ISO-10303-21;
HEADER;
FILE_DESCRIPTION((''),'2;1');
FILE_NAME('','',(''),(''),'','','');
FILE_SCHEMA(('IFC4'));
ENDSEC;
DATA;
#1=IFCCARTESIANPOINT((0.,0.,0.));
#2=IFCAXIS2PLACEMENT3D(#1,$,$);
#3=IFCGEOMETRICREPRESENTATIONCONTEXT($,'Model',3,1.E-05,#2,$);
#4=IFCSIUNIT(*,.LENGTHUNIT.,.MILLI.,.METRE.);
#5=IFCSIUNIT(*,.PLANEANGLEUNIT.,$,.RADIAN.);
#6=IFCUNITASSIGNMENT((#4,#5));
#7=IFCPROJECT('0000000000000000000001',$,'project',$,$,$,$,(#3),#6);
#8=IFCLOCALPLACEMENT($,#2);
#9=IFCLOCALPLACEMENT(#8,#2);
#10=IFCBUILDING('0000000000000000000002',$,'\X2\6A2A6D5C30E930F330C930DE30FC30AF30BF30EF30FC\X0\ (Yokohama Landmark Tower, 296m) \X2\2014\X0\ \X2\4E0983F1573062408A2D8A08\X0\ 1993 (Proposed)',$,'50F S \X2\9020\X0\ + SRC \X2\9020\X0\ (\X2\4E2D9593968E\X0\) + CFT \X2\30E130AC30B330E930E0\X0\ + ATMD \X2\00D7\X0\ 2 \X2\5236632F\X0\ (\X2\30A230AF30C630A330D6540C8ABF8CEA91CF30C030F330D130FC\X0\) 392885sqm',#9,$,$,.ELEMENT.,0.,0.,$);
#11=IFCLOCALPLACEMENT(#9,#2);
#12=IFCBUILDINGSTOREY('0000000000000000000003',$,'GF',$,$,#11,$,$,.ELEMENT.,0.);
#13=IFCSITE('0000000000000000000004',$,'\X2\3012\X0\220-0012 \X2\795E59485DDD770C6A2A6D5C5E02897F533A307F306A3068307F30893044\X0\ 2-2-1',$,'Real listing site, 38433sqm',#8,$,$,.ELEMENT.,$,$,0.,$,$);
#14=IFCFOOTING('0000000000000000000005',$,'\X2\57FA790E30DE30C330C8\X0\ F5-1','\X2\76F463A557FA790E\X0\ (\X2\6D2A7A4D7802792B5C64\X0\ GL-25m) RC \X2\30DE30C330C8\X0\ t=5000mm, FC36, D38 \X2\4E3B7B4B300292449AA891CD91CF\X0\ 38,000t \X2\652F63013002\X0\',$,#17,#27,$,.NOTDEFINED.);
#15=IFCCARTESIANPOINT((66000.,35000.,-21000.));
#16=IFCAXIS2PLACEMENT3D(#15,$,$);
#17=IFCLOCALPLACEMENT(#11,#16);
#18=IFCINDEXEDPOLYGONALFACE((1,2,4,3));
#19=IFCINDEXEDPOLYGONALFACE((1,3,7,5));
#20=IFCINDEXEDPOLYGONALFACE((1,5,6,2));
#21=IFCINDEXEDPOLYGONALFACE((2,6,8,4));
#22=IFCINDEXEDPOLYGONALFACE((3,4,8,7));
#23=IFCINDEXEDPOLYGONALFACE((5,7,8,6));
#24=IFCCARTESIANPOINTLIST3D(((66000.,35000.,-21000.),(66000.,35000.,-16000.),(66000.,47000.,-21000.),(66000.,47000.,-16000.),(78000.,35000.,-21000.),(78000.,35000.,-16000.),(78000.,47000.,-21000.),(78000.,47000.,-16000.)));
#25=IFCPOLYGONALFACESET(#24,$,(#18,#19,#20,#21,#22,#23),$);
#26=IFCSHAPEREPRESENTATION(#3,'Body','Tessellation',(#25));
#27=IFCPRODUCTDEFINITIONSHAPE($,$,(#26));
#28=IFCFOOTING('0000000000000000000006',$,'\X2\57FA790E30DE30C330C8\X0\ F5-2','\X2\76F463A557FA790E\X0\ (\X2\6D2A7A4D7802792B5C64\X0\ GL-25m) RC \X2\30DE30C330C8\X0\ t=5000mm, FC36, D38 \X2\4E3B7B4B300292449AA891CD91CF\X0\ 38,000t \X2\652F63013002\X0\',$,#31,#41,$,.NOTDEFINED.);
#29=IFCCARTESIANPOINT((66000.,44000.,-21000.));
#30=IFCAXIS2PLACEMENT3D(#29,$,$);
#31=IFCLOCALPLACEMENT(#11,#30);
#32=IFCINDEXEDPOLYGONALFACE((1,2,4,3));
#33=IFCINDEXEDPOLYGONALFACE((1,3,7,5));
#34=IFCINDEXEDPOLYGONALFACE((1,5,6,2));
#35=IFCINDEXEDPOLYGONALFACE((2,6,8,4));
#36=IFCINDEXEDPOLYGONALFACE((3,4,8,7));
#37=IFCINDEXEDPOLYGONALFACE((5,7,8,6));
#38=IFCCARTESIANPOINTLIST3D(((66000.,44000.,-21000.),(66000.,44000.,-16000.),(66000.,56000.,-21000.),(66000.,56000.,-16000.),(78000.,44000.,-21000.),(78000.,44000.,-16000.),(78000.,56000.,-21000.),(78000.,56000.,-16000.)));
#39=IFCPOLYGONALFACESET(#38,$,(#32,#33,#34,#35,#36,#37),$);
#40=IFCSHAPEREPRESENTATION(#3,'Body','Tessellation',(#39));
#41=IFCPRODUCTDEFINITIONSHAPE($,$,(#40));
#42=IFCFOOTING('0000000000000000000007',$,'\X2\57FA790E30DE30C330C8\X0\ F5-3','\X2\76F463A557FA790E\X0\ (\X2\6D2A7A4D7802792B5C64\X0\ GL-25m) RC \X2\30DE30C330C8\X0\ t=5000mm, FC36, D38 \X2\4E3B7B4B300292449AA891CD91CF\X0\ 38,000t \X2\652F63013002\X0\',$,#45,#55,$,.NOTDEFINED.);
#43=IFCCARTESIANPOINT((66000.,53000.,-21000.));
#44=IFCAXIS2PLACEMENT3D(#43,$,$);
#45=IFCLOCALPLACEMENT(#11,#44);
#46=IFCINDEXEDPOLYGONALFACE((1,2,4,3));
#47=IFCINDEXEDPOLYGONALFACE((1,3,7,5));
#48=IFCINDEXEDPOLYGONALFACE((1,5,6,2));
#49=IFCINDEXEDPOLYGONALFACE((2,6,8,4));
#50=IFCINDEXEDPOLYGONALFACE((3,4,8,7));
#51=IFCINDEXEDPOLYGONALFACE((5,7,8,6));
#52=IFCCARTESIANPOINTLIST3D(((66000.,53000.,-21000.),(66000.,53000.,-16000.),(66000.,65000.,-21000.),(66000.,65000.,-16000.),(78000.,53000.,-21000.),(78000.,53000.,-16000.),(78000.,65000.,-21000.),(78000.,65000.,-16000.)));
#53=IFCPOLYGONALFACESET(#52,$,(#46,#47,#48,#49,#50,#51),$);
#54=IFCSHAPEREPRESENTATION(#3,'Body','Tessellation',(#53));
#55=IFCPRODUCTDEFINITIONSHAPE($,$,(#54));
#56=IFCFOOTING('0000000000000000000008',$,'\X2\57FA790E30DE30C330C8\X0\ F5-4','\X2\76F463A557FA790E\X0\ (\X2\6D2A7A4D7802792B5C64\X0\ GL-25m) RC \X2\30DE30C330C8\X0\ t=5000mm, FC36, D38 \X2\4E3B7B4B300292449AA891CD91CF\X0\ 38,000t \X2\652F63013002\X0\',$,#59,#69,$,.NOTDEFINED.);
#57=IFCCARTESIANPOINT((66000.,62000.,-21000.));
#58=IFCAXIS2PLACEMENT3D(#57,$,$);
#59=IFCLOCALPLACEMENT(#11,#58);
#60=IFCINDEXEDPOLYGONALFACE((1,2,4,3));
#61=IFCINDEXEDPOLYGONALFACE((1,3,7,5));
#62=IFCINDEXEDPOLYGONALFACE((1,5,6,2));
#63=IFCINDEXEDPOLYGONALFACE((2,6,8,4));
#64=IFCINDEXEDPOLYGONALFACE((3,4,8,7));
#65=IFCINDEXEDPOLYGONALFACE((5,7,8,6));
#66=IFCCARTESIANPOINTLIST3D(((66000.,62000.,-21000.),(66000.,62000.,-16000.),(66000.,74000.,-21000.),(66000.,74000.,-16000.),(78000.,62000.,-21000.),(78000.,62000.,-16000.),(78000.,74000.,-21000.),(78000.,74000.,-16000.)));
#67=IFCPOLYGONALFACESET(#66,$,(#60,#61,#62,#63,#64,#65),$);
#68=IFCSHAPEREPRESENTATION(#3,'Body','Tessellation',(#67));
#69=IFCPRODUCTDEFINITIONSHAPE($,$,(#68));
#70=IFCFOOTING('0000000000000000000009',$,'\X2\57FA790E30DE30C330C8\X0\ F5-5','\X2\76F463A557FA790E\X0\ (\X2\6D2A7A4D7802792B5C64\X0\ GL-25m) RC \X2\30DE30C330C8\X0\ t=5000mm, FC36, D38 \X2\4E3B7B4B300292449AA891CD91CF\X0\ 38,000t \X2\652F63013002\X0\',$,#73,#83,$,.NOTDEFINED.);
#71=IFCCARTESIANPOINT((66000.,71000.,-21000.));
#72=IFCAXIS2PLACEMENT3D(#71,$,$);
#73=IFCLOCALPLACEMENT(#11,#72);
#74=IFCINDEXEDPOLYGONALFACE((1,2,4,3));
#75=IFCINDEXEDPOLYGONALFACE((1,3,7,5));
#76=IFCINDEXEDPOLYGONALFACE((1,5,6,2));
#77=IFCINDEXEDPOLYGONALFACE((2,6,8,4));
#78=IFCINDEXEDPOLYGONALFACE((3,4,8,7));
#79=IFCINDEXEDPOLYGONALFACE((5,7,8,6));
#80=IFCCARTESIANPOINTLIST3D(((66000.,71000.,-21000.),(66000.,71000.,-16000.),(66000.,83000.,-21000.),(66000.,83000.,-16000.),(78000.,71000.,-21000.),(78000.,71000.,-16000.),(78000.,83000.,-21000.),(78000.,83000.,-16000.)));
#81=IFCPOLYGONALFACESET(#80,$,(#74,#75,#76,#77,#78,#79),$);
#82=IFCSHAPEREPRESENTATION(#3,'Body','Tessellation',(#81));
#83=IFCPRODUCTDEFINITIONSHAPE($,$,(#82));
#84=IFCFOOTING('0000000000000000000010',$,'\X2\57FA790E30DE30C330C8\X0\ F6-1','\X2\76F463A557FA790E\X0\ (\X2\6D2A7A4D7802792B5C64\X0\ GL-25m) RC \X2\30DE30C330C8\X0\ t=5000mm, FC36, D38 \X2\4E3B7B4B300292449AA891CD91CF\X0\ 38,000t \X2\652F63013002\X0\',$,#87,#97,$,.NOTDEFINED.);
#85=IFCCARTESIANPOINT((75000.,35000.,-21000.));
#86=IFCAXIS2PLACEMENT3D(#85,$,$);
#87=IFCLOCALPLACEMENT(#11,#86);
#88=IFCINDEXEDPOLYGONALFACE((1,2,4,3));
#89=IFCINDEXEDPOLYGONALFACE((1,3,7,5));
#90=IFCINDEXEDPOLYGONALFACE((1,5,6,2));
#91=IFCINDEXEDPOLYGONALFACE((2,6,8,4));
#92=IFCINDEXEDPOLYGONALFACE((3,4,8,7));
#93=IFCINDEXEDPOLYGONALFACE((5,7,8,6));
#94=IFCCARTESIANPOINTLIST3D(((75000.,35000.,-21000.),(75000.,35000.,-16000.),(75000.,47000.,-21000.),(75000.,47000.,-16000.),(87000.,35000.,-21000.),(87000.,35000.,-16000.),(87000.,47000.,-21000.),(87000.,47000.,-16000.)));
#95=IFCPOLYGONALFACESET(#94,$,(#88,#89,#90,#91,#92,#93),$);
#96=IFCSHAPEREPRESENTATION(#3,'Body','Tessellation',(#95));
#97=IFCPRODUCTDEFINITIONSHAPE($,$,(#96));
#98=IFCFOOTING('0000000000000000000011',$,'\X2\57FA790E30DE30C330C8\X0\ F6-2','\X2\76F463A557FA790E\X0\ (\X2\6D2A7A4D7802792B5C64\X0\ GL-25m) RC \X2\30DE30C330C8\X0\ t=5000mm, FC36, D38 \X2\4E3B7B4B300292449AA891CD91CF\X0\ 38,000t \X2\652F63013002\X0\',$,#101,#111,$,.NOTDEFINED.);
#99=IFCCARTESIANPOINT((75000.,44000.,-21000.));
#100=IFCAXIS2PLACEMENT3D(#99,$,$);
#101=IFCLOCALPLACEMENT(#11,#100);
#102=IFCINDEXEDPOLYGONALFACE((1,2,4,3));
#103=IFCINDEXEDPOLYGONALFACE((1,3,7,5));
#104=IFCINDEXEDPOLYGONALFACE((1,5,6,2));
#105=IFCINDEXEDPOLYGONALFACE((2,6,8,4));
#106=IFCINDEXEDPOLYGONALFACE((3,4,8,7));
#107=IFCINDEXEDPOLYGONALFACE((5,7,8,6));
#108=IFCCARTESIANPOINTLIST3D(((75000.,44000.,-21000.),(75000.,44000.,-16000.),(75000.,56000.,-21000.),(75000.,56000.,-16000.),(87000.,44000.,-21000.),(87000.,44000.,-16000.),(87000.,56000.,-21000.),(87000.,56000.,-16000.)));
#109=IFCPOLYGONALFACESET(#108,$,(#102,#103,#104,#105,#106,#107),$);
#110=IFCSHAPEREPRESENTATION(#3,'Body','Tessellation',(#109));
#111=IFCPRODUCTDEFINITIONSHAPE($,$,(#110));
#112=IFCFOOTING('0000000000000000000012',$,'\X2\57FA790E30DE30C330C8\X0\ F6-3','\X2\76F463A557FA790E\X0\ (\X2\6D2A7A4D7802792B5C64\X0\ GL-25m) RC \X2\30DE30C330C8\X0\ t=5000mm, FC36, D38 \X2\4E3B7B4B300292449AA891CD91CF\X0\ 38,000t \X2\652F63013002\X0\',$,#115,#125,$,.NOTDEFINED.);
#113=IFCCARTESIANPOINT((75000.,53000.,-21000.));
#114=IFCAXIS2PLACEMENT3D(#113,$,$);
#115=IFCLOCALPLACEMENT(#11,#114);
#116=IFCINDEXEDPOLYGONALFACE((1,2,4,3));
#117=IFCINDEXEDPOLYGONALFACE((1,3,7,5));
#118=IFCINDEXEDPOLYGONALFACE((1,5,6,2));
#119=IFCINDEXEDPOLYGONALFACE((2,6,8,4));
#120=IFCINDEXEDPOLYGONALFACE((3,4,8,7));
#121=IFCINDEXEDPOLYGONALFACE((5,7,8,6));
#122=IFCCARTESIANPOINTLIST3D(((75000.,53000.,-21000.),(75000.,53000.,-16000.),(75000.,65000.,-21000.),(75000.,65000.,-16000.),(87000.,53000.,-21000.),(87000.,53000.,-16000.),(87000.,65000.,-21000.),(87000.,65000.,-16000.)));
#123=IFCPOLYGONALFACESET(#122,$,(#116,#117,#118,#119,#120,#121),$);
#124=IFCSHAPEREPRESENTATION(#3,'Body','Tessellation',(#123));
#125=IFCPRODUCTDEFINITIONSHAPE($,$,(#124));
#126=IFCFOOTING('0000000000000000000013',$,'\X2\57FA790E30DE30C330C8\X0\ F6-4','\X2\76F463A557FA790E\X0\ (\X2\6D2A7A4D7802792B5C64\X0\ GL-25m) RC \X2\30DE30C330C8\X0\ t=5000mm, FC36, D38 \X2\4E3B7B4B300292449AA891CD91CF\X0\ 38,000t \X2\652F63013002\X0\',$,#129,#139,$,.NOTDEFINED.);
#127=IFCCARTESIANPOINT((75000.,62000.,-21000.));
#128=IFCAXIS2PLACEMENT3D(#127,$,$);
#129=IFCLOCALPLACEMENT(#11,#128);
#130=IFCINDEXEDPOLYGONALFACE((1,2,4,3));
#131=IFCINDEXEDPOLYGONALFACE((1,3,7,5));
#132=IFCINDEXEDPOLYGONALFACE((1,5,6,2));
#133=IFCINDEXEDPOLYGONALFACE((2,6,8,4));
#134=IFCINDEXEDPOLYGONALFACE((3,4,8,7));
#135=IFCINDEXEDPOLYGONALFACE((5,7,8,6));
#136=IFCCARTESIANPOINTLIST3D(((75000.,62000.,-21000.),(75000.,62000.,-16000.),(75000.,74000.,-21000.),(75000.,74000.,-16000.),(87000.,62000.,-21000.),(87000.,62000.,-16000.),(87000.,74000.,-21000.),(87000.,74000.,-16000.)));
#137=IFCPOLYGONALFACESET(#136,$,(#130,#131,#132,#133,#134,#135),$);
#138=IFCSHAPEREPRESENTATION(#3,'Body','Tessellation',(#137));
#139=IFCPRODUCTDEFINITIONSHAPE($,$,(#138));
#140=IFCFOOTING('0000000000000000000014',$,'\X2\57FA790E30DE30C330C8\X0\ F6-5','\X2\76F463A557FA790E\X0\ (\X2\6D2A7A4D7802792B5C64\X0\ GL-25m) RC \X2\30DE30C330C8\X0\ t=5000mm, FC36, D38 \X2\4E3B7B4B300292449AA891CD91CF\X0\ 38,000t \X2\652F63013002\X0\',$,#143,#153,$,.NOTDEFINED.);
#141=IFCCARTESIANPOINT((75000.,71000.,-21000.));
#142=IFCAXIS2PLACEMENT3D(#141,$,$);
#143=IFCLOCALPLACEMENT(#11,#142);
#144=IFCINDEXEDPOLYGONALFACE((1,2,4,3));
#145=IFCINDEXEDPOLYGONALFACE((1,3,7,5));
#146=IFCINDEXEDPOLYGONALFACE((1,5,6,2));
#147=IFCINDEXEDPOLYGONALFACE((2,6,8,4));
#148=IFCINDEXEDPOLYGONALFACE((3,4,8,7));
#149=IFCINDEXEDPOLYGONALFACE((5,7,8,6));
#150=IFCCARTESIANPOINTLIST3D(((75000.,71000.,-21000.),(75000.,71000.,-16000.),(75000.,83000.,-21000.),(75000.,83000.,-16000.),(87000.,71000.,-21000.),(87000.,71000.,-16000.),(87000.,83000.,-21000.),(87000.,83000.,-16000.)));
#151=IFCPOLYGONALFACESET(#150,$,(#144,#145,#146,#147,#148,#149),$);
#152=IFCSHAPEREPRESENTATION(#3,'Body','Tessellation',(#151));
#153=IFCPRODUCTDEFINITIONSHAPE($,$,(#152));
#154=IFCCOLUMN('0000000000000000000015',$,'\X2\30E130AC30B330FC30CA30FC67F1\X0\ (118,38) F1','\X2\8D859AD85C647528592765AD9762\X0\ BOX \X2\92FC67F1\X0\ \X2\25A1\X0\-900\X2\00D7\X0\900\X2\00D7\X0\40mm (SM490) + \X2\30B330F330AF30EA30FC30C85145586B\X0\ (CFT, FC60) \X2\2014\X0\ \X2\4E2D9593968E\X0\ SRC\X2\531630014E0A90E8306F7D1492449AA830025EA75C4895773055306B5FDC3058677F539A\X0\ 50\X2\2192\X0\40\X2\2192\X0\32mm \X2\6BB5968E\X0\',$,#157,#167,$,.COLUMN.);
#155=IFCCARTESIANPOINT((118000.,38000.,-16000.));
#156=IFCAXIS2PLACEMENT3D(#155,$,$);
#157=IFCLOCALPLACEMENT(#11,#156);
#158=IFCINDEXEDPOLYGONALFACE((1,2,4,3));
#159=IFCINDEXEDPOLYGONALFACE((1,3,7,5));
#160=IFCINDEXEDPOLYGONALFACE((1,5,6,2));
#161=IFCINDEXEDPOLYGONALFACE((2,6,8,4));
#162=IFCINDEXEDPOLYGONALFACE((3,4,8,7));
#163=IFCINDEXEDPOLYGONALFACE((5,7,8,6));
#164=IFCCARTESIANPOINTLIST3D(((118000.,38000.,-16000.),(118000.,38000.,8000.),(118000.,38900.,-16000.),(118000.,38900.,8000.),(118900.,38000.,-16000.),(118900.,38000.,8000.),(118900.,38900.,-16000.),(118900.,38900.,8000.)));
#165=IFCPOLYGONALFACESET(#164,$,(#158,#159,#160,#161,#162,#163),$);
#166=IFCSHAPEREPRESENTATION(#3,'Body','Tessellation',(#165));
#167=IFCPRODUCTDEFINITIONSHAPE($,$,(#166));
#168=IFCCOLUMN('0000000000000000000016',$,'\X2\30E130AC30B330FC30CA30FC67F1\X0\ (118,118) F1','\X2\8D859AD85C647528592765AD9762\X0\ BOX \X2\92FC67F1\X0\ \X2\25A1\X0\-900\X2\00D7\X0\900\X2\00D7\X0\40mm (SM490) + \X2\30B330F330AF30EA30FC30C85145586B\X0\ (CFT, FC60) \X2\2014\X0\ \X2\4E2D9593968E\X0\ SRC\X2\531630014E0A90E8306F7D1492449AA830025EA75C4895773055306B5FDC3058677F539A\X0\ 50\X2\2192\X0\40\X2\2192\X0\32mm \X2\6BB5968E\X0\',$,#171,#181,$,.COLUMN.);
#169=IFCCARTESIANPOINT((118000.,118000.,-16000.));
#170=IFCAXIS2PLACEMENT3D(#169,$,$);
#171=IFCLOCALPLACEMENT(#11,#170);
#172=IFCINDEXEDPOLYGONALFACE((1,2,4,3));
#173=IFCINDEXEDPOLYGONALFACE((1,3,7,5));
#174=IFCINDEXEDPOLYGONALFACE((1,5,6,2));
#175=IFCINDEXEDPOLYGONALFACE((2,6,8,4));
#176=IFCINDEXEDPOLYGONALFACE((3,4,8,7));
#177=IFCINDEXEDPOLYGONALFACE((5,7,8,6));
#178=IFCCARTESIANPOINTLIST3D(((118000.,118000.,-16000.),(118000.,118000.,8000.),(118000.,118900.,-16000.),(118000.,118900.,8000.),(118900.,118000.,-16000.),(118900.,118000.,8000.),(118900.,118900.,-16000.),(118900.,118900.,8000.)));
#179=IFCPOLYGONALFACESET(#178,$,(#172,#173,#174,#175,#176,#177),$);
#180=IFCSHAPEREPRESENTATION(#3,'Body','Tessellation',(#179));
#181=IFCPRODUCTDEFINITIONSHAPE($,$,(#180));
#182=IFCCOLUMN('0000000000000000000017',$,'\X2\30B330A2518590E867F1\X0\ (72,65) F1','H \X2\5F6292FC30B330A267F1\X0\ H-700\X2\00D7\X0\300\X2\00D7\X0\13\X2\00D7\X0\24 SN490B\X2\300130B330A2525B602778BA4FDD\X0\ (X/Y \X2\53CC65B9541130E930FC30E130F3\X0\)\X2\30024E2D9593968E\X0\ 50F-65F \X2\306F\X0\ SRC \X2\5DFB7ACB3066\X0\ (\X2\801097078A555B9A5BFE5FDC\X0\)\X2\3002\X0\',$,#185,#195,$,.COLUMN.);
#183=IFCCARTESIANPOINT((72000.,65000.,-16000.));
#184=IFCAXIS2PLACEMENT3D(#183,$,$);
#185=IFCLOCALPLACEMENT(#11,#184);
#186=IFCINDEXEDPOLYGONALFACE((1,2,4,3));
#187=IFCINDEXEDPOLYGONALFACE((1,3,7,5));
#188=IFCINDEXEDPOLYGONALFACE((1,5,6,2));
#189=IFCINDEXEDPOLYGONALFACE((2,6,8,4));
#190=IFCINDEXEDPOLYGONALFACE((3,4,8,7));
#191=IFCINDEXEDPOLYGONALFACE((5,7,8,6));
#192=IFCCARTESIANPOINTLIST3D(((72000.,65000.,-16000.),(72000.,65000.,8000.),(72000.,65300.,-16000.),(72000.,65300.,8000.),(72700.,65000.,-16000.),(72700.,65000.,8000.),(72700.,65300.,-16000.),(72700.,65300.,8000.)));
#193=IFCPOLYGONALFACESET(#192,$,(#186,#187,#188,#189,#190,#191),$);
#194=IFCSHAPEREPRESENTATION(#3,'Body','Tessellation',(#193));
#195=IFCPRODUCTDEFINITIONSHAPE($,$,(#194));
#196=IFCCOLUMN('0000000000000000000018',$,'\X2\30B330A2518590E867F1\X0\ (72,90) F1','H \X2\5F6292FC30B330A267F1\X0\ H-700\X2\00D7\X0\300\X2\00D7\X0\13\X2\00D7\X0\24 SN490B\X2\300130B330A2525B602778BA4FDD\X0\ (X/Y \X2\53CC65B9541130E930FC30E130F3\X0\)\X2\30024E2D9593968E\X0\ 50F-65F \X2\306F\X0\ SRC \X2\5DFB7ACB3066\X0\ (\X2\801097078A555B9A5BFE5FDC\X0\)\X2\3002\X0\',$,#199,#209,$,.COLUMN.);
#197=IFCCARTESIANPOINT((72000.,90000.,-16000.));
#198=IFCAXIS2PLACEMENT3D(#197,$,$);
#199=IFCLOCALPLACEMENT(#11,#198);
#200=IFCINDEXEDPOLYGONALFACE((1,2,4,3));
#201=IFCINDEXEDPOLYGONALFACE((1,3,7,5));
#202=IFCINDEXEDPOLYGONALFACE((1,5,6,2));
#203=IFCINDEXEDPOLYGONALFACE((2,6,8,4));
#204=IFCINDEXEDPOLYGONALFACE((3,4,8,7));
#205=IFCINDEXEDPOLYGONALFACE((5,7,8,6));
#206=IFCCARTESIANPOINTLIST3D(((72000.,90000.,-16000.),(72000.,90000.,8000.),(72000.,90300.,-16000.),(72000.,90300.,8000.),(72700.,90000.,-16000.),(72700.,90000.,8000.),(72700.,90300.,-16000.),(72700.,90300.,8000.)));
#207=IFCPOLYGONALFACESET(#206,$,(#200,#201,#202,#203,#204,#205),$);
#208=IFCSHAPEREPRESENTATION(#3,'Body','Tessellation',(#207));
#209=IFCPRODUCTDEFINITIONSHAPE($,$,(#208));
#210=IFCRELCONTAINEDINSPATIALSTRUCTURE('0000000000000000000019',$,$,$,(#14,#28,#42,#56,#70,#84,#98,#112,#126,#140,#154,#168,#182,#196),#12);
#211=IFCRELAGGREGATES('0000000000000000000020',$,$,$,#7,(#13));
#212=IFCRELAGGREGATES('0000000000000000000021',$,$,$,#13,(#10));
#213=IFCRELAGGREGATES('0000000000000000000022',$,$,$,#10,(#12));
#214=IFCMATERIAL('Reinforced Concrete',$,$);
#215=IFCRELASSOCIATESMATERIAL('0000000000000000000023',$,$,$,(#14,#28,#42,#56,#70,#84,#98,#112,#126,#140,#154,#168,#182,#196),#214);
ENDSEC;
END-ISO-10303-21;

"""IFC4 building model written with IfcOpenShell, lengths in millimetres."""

from ifc_helpers import new_model, si_unit, frame, frame_2d, origin, place, context, project, spatial, rectangle, extrude, material, element, save


model = new_model("IFC4")

# Units and contexts
model_context = context("Model", 3, precision=1e-05, world=origin())
ifc_project = project(units=[si_unit("LENGTHUNIT", "METRE", prefix="MILLI"), si_unit("PLANEANGLEUNIT", "RADIAN")], contexts=[model_context])

# Site, building, storey
site_placement = place(None, origin())
site = spatial("IfcSite", under=ifc_project, at=site_placement, Name="〒220-0012 神奈川県横浜市西区みなとみらい 2-2-1", ObjectType="Real listing site, 38433sqm", CompositionType="ELEMENT", RefElevation=0.0)
building_placement = place(site_placement, origin())
building = spatial("IfcBuilding", under=site, at=building_placement, Name="横浜ランドマークタワー (Yokohama Landmark Tower, 296m) — 三菱地所設計 1993 (Proposed)", ObjectType="50F S 造 + SRC 造 (中間階) + CFT メガコラム + ATMD × 2 制振 (アクティブ同調質量ダンパー) 392885sqm", CompositionType="ELEMENT", ElevationOfRefHeight=0.0, ElevationOfTerrain=0.0)
storey_placement = place(building_placement, origin())
storey = spatial("IfcBuildingStorey", under=building, at=storey_placement, Name="GF", CompositionType="ELEMENT", Elevation=0.0)

# Footings
ifc_material_1 = material(Name="Reinforced Concrete")
footing_1_placement = place(storey_placement, frame((66000.0, 35000.0, -21000.0)))
element("IfcFooting", 1, at=footing_1_placement, inside=storey, material=ifc_material_1, Name="基礎マット F5-1", Description="直接基礎 (洪積砂礫層 GL-25m) RC マット t=5000mm, FC36, D38 主筋。鉄骨重量 38,000t 支持。", PredefinedType="NOTDEFINED", context=model_context, shape_type="SweptSolid", body=[
    extrude(rectangle(XDim=12000.0, YDim=12000.0, at=frame_2d((6000.0, 6000.0))), frame((66000.0, 35000.0, -21000.0)), (0.0, 0.0, 1.0), 5000.0),
])
footing_2_placement = place(storey_placement, frame((66000.0, 44000.0, -21000.0)))
element("IfcFooting", 2, at=footing_2_placement, inside=storey, material=ifc_material_1, Name="基礎マット F5-2", Description="直接基礎 (洪積砂礫層 GL-25m) RC マット t=5000mm, FC36, D38 主筋。鉄骨重量 38,000t 支持。", PredefinedType="NOTDEFINED", context=model_context, shape_type="SweptSolid", body=[
    extrude(rectangle(XDim=12000.0, YDim=12000.0, at=frame_2d((6000.0, 6000.0))), frame((66000.0, 44000.0, -21000.0)), (0.0, 0.0, 1.0), 5000.0),
])
footing_3_placement = place(storey_placement, frame((66000.0, 53000.0, -21000.0)))
element("IfcFooting", 3, at=footing_3_placement, inside=storey, material=ifc_material_1, Name="基礎マット F5-3", Description="直接基礎 (洪積砂礫層 GL-25m) RC マット t=5000mm, FC36, D38 主筋。鉄骨重量 38,000t 支持。", PredefinedType="NOTDEFINED", context=model_context, shape_type="SweptSolid", body=[
    extrude(rectangle(XDim=12000.0, YDim=12000.0, at=frame_2d((6000.0, 6000.0))), frame((66000.0, 53000.0, -21000.0)), (0.0, 0.0, 1.0), 5000.0),
])
footing_4_placement = place(storey_placement, frame((66000.0, 62000.0, -21000.0)))
element("IfcFooting", 4, at=footing_4_placement, inside=storey, material=ifc_material_1, Name="基礎マット F5-4", Description="直接基礎 (洪積砂礫層 GL-25m) RC マット t=5000mm, FC36, D38 主筋。鉄骨重量 38,000t 支持。", PredefinedType="NOTDEFINED", context=model_context, shape_type="SweptSolid", body=[
    extrude(rectangle(XDim=12000.0, YDim=12000.0, at=frame_2d((6000.0, 6000.0))), frame((66000.0, 62000.0, -21000.0)), (0.0, 0.0, 1.0), 5000.0),
])
footing_5_placement = place(storey_placement, frame((66000.0, 71000.0, -21000.0)))
element("IfcFooting", 5, at=footing_5_placement, inside=storey, material=ifc_material_1, Name="基礎マット F5-5", Description="直接基礎 (洪積砂礫層 GL-25m) RC マット t=5000mm, FC36, D38 主筋。鉄骨重量 38,000t 支持。", PredefinedType="NOTDEFINED", context=model_context, shape_type="SweptSolid", body=[
    extrude(rectangle(XDim=12000.0, YDim=12000.0, at=frame_2d((6000.0, 6000.0))), frame((66000.0, 71000.0, -21000.0)), (0.0, 0.0, 1.0), 5000.0),
])
footing_6_placement = place(storey_placement, frame((75000.0, 35000.0, -21000.0)))
element("IfcFooting", 6, at=footing_6_placement, inside=storey, material=ifc_material_1, Name="基礎マット F6-1", Description="直接基礎 (洪積砂礫層 GL-25m) RC マット t=5000mm, FC36, D38 主筋。鉄骨重量 38,000t 支持。", PredefinedType="NOTDEFINED", context=model_context, shape_type="SweptSolid", body=[
    extrude(rectangle(XDim=12000.0, YDim=12000.0, at=frame_2d((6000.0, 6000.0))), frame((75000.0, 35000.0, -21000.0)), (0.0, 0.0, 1.0), 5000.0),
])
footing_7_placement = place(storey_placement, frame((75000.0, 44000.0, -21000.0)))
element("IfcFooting", 7, at=footing_7_placement, inside=storey, material=ifc_material_1, Name="基礎マット F6-2", Description="直接基礎 (洪積砂礫層 GL-25m) RC マット t=5000mm, FC36, D38 主筋。鉄骨重量 38,000t 支持。", PredefinedType="NOTDEFINED", context=model_context, shape_type="SweptSolid", body=[
    extrude(rectangle(XDim=12000.0, YDim=12000.0, at=frame_2d((6000.0, 6000.0))), frame((75000.0, 44000.0, -21000.0)), (0.0, 0.0, 1.0), 5000.0),
])
footing_8_placement = place(storey_placement, frame((75000.0, 53000.0, -21000.0)))
element("IfcFooting", 8, at=footing_8_placement, inside=storey, material=ifc_material_1, Name="基礎マット F6-3", Description="直接基礎 (洪積砂礫層 GL-25m) RC マット t=5000mm, FC36, D38 主筋。鉄骨重量 38,000t 支持。", PredefinedType="NOTDEFINED", context=model_context, shape_type="SweptSolid", body=[
    extrude(rectangle(XDim=12000.0, YDim=12000.0, at=frame_2d((6000.0, 6000.0))), frame((75000.0, 53000.0, -21000.0)), (0.0, 0.0, 1.0), 5000.0),
])
footing_9_placement = place(storey_placement, frame((75000.0, 62000.0, -21000.0)))
element("IfcFooting", 9, at=footing_9_placement, inside=storey, material=ifc_material_1, Name="基礎マット F6-4", Description="直接基礎 (洪積砂礫層 GL-25m) RC マット t=5000mm, FC36, D38 主筋。鉄骨重量 38,000t 支持。", PredefinedType="NOTDEFINED", context=model_context, shape_type="SweptSolid", body=[
    extrude(rectangle(XDim=12000.0, YDim=12000.0, at=frame_2d((6000.0, 6000.0))), frame((75000.0, 62000.0, -21000.0)), (0.0, 0.0, 1.0), 5000.0),
])
footing_10_placement = place(storey_placement, frame((75000.0, 71000.0, -21000.0)))
element("IfcFooting", 10, at=footing_10_placement, inside=storey, material=ifc_material_1, Name="基礎マット F6-5", Description="直接基礎 (洪積砂礫層 GL-25m) RC マット t=5000mm, FC36, D38 主筋。鉄骨重量 38,000t 支持。", PredefinedType="NOTDEFINED", context=model_context, shape_type="SweptSolid", body=[
    extrude(rectangle(XDim=12000.0, YDim=12000.0, at=frame_2d((6000.0, 6000.0))), frame((75000.0, 71000.0, -21000.0)), (0.0, 0.0, 1.0), 5000.0),
])

# Columns
column_1_placement = place(storey_placement, frame((118000.0, 38000.0, -16000.0)))
element("IfcColumn", 11, at=column_1_placement, inside=storey, material=ifc_material_1, Name="メガコーナー柱 (118,38) F1", Description="超高層用大断面 BOX 鋼柱 □-900×900×40mm (SM490) + コンクリート充填 (CFT, FC60) — 中間階 SRC化、上部は純鉄骨。座屈長さに応じ板厚 50→40→32mm 段階", PredefinedType="COLUMN", context=model_context, shape_type="SweptSolid", body=[
    extrude(rectangle(XDim=900.0, YDim=900.0, at=frame_2d((450.0, 450.0))), frame((118000.0, 38000.0, -16000.0)), (0.0, 0.0, 1.0), 24000.0),
])
column_2_placement = place(storey_placement, frame((118000.0, 118000.0, -16000.0)))
element("IfcColumn", 12, at=column_2_placement, inside=storey, material=ifc_material_1, Name="メガコーナー柱 (118,118) F1", Description="超高層用大断面 BOX 鋼柱 □-900×900×40mm (SM490) + コンクリート充填 (CFT, FC60) — 中間階 SRC化、上部は純鉄骨。座屈長さに応じ板厚 50→40→32mm 段階", PredefinedType="COLUMN", context=model_context, shape_type="SweptSolid", body=[
    extrude(rectangle(XDim=900.0, YDim=900.0, at=frame_2d((450.0, 450.0))), frame((118000.0, 118000.0, -16000.0)), (0.0, 0.0, 1.0), 24000.0),
])
column_3_placement = place(storey_placement, frame((72000.0, 65000.0, -16000.0)))
element("IfcColumn", 13, at=column_3_placement, inside=storey, material=ifc_material_1, Name="コア内部柱 (72,65) F1", Description="H 形鋼コア柱 H-700×300×13×24 SN490B、コア剛性確保 (X/Y 双方向ラーメン)。中間階 50F-65F は SRC 巻立て (耐震評定対応)。", PredefinedType="COLUMN", context=model_context, shape_type="SweptSolid", body=[
    extrude(rectangle(XDim=700.0, YDim=300.0, at=frame_2d((350.0, 150.0))), frame((72000.0, 65000.0, -16000.0)), (0.0, 0.0, 1.0), 24000.0),
])
column_4_placement = place(storey_placement, frame((72000.0, 90000.0, -16000.0)))
element("IfcColumn", 14, at=column_4_placement, inside=storey, material=ifc_material_1, Name="コア内部柱 (72,90) F1", Description="H 形鋼コア柱 H-700×300×13×24 SN490B、コア剛性確保 (X/Y 双方向ラーメン)。中間階 50F-65F は SRC 巻立て (耐震評定対応)。", PredefinedType="COLUMN", context=model_context, shape_type="SweptSolid", body=[
    extrude(rectangle(XDim=700.0, YDim=300.0, at=frame_2d((350.0, 150.0))), frame((72000.0, 90000.0, -16000.0)), (0.0, 0.0, 1.0), 24000.0),
])

save(model, "model.ifc")
